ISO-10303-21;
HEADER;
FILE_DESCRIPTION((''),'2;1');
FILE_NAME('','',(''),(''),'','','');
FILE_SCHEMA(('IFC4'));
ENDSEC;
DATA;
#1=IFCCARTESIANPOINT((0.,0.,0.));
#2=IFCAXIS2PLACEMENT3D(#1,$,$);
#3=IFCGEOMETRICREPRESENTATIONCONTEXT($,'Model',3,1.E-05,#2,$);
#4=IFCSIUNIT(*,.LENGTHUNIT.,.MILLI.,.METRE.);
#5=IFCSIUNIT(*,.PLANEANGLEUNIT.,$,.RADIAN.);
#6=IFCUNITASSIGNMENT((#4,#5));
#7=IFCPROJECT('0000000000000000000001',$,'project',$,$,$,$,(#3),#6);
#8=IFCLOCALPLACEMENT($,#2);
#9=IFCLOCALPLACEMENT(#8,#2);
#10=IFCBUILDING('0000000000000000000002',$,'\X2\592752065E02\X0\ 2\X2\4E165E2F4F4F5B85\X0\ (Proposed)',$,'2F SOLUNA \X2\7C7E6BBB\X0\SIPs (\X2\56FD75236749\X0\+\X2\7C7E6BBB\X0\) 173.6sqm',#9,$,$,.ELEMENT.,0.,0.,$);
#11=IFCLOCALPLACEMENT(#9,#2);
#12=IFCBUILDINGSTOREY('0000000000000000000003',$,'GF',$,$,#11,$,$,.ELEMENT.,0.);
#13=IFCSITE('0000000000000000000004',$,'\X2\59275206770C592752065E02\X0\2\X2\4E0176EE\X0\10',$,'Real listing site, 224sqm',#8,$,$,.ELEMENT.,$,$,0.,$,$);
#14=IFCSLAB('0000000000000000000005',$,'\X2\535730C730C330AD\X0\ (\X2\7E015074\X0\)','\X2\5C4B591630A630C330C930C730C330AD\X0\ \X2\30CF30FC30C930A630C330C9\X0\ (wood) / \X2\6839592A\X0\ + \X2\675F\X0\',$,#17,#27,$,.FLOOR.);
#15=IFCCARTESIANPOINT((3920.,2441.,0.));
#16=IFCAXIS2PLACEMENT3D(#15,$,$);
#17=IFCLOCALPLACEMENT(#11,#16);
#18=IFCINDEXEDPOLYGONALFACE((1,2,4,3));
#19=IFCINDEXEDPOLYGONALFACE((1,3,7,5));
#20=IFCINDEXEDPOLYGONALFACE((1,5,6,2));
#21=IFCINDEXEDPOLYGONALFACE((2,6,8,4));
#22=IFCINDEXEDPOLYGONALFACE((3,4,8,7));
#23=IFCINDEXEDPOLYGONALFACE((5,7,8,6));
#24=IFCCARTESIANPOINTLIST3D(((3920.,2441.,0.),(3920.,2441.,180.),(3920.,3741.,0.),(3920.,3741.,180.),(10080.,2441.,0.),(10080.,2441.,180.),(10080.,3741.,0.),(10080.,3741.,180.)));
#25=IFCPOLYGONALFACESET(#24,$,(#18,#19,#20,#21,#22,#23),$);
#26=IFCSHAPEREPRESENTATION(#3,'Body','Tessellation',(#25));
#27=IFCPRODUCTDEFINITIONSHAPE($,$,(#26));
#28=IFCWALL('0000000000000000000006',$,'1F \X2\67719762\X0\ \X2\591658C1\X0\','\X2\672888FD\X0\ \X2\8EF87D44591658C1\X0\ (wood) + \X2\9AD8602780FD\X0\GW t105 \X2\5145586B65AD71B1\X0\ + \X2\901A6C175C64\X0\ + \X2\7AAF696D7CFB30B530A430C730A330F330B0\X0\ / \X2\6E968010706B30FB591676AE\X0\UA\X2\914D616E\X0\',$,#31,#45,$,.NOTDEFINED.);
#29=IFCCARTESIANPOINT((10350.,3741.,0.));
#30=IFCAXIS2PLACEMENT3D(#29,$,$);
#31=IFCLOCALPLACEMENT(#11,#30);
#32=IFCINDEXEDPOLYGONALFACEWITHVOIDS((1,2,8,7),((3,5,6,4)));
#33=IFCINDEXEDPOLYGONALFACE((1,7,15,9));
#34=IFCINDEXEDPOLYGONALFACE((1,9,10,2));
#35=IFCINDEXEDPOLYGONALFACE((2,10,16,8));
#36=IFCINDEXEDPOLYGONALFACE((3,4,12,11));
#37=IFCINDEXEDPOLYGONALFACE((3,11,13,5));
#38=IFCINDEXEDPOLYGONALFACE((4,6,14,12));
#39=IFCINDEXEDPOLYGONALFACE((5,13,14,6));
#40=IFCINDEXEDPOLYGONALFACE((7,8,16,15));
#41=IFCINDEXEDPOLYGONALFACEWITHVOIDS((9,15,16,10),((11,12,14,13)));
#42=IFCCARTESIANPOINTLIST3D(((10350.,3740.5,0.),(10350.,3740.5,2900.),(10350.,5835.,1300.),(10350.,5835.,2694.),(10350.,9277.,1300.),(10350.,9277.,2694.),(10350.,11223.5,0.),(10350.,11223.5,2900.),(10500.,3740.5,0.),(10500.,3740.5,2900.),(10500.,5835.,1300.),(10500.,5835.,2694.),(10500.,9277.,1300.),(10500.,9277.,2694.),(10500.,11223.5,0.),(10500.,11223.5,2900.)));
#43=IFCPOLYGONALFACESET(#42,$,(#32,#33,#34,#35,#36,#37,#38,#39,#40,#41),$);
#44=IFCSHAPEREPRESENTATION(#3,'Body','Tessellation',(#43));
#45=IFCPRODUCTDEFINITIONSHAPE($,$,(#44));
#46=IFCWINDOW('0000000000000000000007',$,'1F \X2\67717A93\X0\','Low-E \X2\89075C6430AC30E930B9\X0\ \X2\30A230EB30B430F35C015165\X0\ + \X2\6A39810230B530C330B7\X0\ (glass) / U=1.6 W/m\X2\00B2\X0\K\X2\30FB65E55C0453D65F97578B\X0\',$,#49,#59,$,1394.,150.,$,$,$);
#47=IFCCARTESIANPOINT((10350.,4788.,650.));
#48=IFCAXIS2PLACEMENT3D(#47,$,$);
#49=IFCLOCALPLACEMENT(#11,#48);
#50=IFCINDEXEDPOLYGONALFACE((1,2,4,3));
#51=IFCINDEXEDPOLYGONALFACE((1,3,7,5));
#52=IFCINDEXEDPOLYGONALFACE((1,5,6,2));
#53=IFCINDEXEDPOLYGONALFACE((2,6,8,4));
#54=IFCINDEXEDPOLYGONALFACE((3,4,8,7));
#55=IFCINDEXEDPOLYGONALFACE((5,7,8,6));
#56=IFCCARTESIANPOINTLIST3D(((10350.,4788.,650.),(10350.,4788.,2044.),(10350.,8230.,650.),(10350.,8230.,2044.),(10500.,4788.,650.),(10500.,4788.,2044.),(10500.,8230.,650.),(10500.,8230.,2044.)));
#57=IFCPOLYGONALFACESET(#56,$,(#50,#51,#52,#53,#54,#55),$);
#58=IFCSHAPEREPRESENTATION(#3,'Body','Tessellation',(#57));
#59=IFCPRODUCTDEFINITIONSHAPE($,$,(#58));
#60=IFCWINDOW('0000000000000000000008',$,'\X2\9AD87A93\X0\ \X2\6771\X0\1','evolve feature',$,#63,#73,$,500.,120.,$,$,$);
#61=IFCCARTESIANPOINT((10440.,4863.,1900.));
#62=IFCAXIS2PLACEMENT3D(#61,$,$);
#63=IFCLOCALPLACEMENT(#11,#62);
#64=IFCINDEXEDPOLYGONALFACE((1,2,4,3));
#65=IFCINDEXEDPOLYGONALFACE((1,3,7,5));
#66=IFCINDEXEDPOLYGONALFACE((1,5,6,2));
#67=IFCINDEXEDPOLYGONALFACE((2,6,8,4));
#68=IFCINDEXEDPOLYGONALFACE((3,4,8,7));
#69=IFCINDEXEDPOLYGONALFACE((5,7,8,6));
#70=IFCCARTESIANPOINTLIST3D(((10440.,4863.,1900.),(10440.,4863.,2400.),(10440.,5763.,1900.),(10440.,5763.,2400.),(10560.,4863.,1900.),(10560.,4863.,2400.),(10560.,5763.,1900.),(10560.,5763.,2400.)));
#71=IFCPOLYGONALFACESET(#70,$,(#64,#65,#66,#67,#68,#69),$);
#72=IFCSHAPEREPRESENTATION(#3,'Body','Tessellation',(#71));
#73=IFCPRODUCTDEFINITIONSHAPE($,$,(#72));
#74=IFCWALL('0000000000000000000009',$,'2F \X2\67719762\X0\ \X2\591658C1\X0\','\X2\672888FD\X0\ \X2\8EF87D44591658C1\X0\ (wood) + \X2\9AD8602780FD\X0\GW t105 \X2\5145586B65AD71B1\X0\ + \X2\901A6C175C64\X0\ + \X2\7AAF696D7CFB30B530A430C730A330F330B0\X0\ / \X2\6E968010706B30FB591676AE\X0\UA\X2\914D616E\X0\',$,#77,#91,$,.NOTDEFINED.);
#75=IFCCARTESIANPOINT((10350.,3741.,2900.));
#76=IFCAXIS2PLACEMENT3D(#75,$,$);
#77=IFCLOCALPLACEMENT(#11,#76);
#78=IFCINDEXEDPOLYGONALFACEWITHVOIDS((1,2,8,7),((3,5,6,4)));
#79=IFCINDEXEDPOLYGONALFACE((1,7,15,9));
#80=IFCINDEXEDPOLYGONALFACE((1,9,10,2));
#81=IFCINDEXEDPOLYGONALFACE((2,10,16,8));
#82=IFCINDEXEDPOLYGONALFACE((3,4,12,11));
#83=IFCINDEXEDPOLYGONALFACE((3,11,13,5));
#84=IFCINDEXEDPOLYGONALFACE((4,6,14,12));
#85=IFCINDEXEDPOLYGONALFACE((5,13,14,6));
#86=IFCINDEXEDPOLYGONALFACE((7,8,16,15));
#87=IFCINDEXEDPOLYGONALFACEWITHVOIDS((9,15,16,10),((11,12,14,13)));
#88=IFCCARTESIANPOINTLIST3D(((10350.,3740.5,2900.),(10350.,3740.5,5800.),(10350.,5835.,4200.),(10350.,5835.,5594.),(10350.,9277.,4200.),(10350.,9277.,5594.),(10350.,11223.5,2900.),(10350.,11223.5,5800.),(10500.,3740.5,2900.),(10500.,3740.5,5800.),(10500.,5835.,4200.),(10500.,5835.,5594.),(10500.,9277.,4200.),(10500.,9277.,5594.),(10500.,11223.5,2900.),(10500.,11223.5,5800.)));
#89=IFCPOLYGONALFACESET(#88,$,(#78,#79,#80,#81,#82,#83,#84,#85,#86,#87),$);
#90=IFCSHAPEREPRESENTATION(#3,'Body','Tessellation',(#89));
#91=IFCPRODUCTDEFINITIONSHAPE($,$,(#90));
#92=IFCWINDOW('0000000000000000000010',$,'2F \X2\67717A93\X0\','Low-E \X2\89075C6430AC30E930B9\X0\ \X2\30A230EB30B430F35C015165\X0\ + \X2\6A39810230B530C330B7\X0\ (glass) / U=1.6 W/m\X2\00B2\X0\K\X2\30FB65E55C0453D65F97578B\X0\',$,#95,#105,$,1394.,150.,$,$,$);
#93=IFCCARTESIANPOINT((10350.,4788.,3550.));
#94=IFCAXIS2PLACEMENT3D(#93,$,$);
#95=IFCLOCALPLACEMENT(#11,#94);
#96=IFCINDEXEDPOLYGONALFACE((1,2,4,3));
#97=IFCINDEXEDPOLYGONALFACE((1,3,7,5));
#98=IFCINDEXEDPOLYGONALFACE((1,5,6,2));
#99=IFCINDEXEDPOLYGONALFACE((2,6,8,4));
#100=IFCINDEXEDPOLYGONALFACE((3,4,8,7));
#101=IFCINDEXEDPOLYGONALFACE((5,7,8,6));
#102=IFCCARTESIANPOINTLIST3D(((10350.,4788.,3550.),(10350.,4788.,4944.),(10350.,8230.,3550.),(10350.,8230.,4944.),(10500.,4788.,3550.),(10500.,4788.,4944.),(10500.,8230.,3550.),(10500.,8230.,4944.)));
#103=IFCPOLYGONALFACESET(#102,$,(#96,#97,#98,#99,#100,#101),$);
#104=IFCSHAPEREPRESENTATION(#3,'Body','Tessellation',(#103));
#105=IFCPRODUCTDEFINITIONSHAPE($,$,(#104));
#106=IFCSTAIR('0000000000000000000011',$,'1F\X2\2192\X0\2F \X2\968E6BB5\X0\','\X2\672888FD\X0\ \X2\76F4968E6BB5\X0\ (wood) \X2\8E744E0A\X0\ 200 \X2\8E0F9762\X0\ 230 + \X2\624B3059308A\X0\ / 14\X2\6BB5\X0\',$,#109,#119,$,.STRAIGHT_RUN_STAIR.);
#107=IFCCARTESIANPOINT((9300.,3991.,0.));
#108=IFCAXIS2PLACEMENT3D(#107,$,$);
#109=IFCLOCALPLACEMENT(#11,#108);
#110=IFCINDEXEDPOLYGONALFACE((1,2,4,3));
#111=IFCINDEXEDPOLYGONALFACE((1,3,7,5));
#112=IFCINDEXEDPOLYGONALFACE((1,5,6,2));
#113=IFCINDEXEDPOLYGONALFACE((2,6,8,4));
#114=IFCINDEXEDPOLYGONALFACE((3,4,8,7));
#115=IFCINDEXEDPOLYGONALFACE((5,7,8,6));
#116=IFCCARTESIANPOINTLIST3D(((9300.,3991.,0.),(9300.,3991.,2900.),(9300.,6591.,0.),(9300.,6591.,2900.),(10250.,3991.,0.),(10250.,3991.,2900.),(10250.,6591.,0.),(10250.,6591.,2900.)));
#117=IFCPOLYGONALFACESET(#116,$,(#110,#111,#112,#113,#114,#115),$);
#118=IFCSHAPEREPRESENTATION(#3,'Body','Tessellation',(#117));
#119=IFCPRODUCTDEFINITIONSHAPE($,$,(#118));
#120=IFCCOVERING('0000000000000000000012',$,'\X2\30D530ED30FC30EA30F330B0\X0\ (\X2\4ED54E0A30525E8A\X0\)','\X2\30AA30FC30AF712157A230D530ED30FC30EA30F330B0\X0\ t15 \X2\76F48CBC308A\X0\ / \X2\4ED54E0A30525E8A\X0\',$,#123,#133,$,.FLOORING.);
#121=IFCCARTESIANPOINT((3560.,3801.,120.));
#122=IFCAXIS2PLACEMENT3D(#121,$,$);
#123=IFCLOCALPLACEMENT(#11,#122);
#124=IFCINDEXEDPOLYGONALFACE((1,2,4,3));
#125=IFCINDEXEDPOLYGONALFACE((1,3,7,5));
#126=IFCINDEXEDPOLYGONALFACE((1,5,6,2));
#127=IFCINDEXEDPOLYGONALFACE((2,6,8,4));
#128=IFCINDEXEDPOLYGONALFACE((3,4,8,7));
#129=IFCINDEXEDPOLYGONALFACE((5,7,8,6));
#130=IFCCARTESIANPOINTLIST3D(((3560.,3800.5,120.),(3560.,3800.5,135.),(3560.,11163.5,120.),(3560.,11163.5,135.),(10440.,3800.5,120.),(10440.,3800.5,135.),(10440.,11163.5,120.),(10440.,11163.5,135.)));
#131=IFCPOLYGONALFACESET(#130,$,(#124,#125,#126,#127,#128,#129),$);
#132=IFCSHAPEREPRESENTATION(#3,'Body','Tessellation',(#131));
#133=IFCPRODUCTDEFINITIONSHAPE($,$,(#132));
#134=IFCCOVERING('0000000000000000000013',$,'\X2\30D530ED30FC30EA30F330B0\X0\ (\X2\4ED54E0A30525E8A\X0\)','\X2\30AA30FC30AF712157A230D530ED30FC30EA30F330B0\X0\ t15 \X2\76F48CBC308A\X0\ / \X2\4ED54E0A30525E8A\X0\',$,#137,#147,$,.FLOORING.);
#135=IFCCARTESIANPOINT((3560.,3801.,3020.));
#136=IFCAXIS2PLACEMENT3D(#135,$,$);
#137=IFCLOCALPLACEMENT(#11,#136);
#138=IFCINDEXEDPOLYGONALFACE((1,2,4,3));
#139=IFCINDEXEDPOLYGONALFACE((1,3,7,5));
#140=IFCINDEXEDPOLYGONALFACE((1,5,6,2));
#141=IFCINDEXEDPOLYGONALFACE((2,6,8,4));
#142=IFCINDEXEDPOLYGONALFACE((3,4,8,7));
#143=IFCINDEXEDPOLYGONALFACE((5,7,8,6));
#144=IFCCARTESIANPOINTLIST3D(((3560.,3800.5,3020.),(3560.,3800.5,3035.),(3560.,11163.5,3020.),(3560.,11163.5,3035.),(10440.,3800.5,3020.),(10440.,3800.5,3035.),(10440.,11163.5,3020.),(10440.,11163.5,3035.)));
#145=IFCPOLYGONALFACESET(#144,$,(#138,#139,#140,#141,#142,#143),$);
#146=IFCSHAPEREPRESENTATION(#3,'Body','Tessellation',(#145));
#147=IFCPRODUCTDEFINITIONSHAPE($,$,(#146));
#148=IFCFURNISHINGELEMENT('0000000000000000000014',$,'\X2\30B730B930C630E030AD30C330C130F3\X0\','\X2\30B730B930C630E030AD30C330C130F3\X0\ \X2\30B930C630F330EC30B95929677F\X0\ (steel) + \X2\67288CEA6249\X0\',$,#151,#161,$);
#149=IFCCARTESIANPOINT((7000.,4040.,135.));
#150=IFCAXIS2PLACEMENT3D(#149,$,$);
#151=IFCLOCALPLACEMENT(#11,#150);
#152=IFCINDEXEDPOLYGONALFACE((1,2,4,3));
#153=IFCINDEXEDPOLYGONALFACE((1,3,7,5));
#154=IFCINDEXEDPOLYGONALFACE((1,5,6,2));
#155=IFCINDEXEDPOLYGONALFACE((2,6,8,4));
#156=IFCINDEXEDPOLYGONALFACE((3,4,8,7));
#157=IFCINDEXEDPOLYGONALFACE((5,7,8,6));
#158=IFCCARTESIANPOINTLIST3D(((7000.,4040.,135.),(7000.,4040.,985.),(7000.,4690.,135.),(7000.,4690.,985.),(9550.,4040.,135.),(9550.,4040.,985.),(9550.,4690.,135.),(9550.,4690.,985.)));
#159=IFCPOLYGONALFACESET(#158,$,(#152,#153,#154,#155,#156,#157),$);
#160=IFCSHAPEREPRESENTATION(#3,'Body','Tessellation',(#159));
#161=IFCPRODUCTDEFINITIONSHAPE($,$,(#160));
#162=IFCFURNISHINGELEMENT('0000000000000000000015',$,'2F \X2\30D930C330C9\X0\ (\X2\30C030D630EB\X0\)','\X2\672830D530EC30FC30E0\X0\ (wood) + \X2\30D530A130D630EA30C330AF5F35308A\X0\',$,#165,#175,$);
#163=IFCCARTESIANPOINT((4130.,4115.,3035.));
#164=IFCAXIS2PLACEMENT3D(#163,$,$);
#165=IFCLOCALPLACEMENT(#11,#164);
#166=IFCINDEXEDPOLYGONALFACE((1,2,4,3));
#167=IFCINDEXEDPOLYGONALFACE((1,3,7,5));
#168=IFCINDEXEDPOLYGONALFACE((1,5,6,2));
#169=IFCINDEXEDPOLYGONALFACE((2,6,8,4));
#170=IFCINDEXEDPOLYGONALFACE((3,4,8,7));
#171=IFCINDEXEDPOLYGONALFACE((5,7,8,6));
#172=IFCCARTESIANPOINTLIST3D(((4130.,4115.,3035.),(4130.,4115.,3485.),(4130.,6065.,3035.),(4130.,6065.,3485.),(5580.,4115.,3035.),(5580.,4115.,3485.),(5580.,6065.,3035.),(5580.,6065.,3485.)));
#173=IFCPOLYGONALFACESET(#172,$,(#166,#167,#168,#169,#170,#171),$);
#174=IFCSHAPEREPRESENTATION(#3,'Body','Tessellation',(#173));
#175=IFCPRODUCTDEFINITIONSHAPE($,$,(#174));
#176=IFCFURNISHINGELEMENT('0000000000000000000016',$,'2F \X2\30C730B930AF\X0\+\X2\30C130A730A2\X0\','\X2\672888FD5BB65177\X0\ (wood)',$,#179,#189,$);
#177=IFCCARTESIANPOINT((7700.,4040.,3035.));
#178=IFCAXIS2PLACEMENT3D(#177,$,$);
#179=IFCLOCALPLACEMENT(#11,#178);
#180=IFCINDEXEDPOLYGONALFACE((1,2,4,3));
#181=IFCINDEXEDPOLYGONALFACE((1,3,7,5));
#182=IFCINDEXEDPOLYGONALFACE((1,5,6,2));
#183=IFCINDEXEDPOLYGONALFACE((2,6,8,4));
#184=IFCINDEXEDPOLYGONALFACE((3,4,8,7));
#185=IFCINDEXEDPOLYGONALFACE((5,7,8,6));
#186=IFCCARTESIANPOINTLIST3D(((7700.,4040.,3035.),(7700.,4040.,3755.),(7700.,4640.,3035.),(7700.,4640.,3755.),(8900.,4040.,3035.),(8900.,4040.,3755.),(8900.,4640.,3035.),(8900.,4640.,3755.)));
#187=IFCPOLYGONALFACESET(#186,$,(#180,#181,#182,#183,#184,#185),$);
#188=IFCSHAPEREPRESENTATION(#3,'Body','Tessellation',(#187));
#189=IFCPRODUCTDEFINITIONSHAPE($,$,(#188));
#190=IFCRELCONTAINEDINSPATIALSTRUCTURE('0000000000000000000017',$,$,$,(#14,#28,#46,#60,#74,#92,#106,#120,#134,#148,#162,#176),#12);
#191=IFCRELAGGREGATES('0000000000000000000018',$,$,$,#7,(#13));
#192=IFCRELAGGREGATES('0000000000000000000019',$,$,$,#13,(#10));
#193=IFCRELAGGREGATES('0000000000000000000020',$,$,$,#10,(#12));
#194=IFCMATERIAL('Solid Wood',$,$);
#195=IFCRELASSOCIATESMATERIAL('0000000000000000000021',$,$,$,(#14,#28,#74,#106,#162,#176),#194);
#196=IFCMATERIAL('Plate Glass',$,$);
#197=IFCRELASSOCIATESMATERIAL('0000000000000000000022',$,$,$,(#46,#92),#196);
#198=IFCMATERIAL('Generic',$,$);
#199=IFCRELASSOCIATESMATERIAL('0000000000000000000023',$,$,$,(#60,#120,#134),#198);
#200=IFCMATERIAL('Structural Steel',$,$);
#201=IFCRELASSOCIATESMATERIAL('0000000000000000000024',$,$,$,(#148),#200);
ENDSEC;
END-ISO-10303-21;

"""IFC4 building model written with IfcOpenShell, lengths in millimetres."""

from ifc_helpers import new_model, si_unit, frame, frame_2d, origin, place, context, project, spatial, rectangle, extrude, material, element, fill, save


model = new_model("IFC4")

# Units and contexts
model_context = context("Model", 3, precision=1e-05, world=origin())
ifc_project = project(units=[si_unit("LENGTHUNIT", "METRE", prefix="MILLI"), si_unit("PLANEANGLEUNIT", "RADIAN")], contexts=[model_context])

# Site, building, storey
site_placement = place(None, origin())
site = spatial("IfcSite", under=ifc_project, at=site_placement, Name="大分県大分市2丁目10", ObjectType="Real listing site, 224sqm", CompositionType="ELEMENT", RefElevation=0.0)
building_placement = place(site_placement, origin())
building = spatial("IfcBuilding", under=site, at=building_placement, Name="大分市 2世帯住宅 (Proposed)", ObjectType="2F SOLUNA 籾殻SIPs (国産杉+籾殻) 173.6sqm", CompositionType="ELEMENT", ElevationOfRefHeight=0.0, ElevationOfTerrain=0.0)
storey_placement = place(building_placement, origin())
storey = spatial("IfcBuildingStorey", under=building, at=storey_placement, Name="GF", CompositionType="ELEMENT", Elevation=0.0)

# Slab
ifc_material_1 = material(Name="Solid Wood")
slab_placement = place(storey_placement, frame((3920.0, 2441.0, 0.0)))
element("IfcSlab", 1, at=slab_placement, inside=storey, material=ifc_material_1, Name="南デッキ (縁側)", Description="屋外ウッドデッキ ハードウッド (wood) / 根太 + 束", PredefinedType="FLOOR", context=model_context, shape_type="SweptSolid", body=[
    extrude(rectangle(XDim=6160.0, YDim=1300.0, at=frame_2d((3080.0, 650.0))), frame((3920.0, 2441.0, 0.0)), (0.0, 0.0, 1.0), 180.0),
])

# Wall, openings, windows
wall_1_placement = place(storey_placement, frame((10350.0, 3741.0, 0.0)))
wall_1 = element("IfcWall", 2, at=wall_1_placement, inside=storey, material=ifc_material_1, Name="1F 東面 外壁", Description="木製 軸組外壁 (wood) + 高性能GW t105 充填断熱 + 通気層 + 窯業系サイディング / 準耐火・外皮UA配慮", PredefinedType="NOTDEFINED", context=model_context, shape_type="SweptSolid", body=[
    extrude(rectangle(XDim=150.0, YDim=7483.0, at=frame_2d((75.0, 3741.0))), frame((10350.0, 3741.0, 0.0)), (0.0, 0.0, 1.0), 2900.0),
])
opening_1_placement = place(storey_placement, frame((10350.0, 4788.0, 650.0)))
opening_1 = element("IfcOpeningElement", 3, at=opening_1_placement, cuts=wall_1, PredefinedType="NOTDEFINED", context=model_context, shape_type="SweptSolid", body=[
    extrude(rectangle(XDim=150.0, YDim=3442.0, at=frame_2d((75.0, 1721.0))), frame((10350.0, 4788.0, 650.0)), (0.0, 0.0, 1.0), 1394.0),
])
opening_2_placement = place(storey_placement, frame((10440.0, 4863.0, 1900.0)))
opening_2 = element("IfcOpeningElement", 4, at=opening_2_placement, cuts=wall_1, PredefinedType="NOTDEFINED", context=model_context, shape_type="SweptSolid", body=[
    extrude(rectangle(XDim=120.0, YDim=900.0, at=frame_2d((60.0, 450.0))), frame((10440.0, 4863.0, 1900.0)), (0.0, 0.0, 1.0), 500.0),
])
ifc_material_2 = material(Name="Plate Glass")
window_1_placement = place(storey_placement, frame((10350.0, 4788.0, 650.0)))
window_1 = element("IfcWindow", 5, at=window_1_placement, inside=storey, material=ifc_material_2, Name="1F 東窓", Description="Low-E 複層ガラス アルゴン封入 + 樹脂サッシ (glass) / U=1.6 W/m²K・日射取得型", OverallHeight=1394.0, OverallWidth=150.0, context=model_context, shape_type="SweptSolid", body=[
    extrude(rectangle(XDim=150.0, YDim=3442.0, at=frame_2d((75.0, 1721.0))), frame((10350.0, 4788.0, 650.0)), (0.0, 0.0, 1.0), 1394.0),
])
fill(opening_1, window_1)
ifc_material_3 = material(Name="Generic")
window_2_placement = place(storey_placement, frame((10440.0, 4863.0, 1900.0)))
window_2 = element("IfcWindow", 6, at=window_2_placement, inside=storey, material=ifc_material_3, Name="高窓 東1", Description="evolve feature", OverallHeight=500.0, OverallWidth=120.0, context=model_context, shape_type="SweptSolid", body=[
    extrude(rectangle(XDim=120.0, YDim=900.0, at=frame_2d((60.0, 450.0))), frame((10440.0, 4863.0, 1900.0)), (0.0, 0.0, 1.0), 500.0),
])
fill(opening_2, window_2)

# Wall, opening, window
wall_2_placement = place(storey_placement, frame((10350.0, 3741.0, 2900.0)))
wall_2 = element("IfcWall", 7, at=wall_2_placement, inside=storey, material=ifc_material_1, Name="2F 東面 外壁", Description="木製 軸組外壁 (wood) + 高性能GW t105 充填断熱 + 通気層 + 窯業系サイディング / 準耐火・外皮UA配慮", PredefinedType="NOTDEFINED", context=model_context, shape_type="SweptSolid", body=[
    extrude(rectangle(XDim=150.0, YDim=7483.0, at=frame_2d((75.0, 3741.0))), frame((10350.0, 3741.0, 2900.0)), (0.0, 0.0, 1.0), 2900.0),
])
opening_3_placement = place(storey_placement, frame((10350.0, 4788.0, 3550.0)))
opening_3 = element("IfcOpeningElement", 8, at=opening_3_placement, cuts=wall_2, PredefinedType="NOTDEFINED", context=model_context, shape_type="SweptSolid", body=[
    extrude(rectangle(XDim=150.0, YDim=3442.0, at=frame_2d((75.0, 1721.0))), frame((10350.0, 4788.0, 3550.0)), (0.0, 0.0, 1.0), 1394.0),
])
window_3_placement = place(storey_placement, frame((10350.0, 4788.0, 3550.0)))
window_3 = element("IfcWindow", 9, at=window_3_placement, inside=storey, material=ifc_material_2, Name="2F 東窓", Description="Low-E 複層ガラス アルゴン封入 + 樹脂サッシ (glass) / U=1.6 W/m²K・日射取得型", OverallHeight=1394.0, OverallWidth=150.0, context=model_context, shape_type="SweptSolid", body=[
    extrude(rectangle(XDim=150.0, YDim=3442.0, at=frame_2d((75.0, 1721.0))), frame((10350.0, 4788.0, 3550.0)), (0.0, 0.0, 1.0), 1394.0),
])
fill(opening_3, window_3)

# Stair
stair_placement = place(storey_placement, frame((9300.0, 3991.0, 0.0)))
element("IfcStair", 10, at=stair_placement, inside=storey, material=ifc_material_1, Name="1F→2F 階段", Description="木製 直階段 (wood) 蹴上 200 踏面 230 + 手すり / 14段", PredefinedType="STRAIGHT_RUN_STAIR", context=model_context, shape_type="SweptSolid", body=[
    extrude(rectangle(XDim=950.0, YDim=2600.0, at=frame_2d((475.0, 1300.0))), frame((9300.0, 3991.0, 0.0)), (0.0, 0.0, 1.0), 2900.0),
])

# Coverings
covering_1_placement = place(storey_placement, frame((3560.0, 3801.0, 120.0)))
element("IfcCovering", 11, at=covering_1_placement, inside=storey, material=ifc_material_3, Name="フローリング (仕上げ床)", Description="オーク無垢フローリング t15 直貼り / 仕上げ床", PredefinedType="FLOORING", context=model_context, shape_type="SweptSolid", body=[
    extrude(rectangle(XDim=6880.0, YDim=7363.0, at=frame_2d((3440.0, 3681.0))), frame((3560.0, 3801.0, 120.0)), (0.0, 0.0, 1.0), 15.0),
])
covering_2_placement = place(storey_placement, frame((3560.0, 3801.0, 3020.0)))
element("IfcCovering", 12, at=covering_2_placement, inside=storey, material=ifc_material_3, Name="フローリング (仕上げ床)", Description="オーク無垢フローリング t15 直貼り / 仕上げ床", PredefinedType="FLOORING", context=model_context, shape_type="SweptSolid", body=[
    extrude(rectangle(XDim=6880.0, YDim=7363.0, at=frame_2d((3440.0, 3681.0))), frame((3560.0, 3801.0, 3020.0)), (0.0, 0.0, 1.0), 15.0),
])

# Furnishing elements
ifc_material_4 = material(Name="Structural Steel")
furnishing_1_placement = place(storey_placement, frame((7000.0, 4040.0, 135.0)))
element("IfcFurnishingElement", 13, at=furnishing_1_placement, inside=storey, material=ifc_material_4, Name="システムキッチン", Description="システムキッチン ステンレス天板 (steel) + 木質扉", context=model_context, shape_type="SweptSolid", body=[
    extrude(rectangle(XDim=2550.0, YDim=650.0, at=frame_2d((1275.0, 325.0))), frame((7000.0, 4040.0, 135.0)), (0.0, 0.0, 1.0), 850.0),
])
furnishing_2_placement = place(storey_placement, frame((4130.0, 4115.0, 3035.0)))
element("IfcFurnishingElement", 14, at=furnishing_2_placement, inside=storey, material=ifc_material_1, Name="2F ベッド (ダブル)", Description="木フレーム (wood) + ファブリック張り", context=model_context, shape_type="SweptSolid", body=[
    extrude(rectangle(XDim=1450.0, YDim=1950.0, at=frame_2d((725.0, 975.0))), frame((4130.0, 4115.0, 3035.0)), (0.0, 0.0, 1.0), 450.0),
])
furnishing_3_placement = place(storey_placement, frame((7700.0, 4040.0, 3035.0)))
element("IfcFurnishingElement", 15, at=furnishing_3_placement, inside=storey, material=ifc_material_1, Name="2F デスク+チェア", Description="木製家具 (wood)", context=model_context, shape_type="SweptSolid", body=[
    extrude(rectangle(XDim=1200.0, YDim=600.0, at=frame_2d((600.0, 300.0))), frame((7700.0, 4040.0, 3035.0)), (0.0, 0.0, 1.0), 720.0),
])

save(model, "model.ifc")
